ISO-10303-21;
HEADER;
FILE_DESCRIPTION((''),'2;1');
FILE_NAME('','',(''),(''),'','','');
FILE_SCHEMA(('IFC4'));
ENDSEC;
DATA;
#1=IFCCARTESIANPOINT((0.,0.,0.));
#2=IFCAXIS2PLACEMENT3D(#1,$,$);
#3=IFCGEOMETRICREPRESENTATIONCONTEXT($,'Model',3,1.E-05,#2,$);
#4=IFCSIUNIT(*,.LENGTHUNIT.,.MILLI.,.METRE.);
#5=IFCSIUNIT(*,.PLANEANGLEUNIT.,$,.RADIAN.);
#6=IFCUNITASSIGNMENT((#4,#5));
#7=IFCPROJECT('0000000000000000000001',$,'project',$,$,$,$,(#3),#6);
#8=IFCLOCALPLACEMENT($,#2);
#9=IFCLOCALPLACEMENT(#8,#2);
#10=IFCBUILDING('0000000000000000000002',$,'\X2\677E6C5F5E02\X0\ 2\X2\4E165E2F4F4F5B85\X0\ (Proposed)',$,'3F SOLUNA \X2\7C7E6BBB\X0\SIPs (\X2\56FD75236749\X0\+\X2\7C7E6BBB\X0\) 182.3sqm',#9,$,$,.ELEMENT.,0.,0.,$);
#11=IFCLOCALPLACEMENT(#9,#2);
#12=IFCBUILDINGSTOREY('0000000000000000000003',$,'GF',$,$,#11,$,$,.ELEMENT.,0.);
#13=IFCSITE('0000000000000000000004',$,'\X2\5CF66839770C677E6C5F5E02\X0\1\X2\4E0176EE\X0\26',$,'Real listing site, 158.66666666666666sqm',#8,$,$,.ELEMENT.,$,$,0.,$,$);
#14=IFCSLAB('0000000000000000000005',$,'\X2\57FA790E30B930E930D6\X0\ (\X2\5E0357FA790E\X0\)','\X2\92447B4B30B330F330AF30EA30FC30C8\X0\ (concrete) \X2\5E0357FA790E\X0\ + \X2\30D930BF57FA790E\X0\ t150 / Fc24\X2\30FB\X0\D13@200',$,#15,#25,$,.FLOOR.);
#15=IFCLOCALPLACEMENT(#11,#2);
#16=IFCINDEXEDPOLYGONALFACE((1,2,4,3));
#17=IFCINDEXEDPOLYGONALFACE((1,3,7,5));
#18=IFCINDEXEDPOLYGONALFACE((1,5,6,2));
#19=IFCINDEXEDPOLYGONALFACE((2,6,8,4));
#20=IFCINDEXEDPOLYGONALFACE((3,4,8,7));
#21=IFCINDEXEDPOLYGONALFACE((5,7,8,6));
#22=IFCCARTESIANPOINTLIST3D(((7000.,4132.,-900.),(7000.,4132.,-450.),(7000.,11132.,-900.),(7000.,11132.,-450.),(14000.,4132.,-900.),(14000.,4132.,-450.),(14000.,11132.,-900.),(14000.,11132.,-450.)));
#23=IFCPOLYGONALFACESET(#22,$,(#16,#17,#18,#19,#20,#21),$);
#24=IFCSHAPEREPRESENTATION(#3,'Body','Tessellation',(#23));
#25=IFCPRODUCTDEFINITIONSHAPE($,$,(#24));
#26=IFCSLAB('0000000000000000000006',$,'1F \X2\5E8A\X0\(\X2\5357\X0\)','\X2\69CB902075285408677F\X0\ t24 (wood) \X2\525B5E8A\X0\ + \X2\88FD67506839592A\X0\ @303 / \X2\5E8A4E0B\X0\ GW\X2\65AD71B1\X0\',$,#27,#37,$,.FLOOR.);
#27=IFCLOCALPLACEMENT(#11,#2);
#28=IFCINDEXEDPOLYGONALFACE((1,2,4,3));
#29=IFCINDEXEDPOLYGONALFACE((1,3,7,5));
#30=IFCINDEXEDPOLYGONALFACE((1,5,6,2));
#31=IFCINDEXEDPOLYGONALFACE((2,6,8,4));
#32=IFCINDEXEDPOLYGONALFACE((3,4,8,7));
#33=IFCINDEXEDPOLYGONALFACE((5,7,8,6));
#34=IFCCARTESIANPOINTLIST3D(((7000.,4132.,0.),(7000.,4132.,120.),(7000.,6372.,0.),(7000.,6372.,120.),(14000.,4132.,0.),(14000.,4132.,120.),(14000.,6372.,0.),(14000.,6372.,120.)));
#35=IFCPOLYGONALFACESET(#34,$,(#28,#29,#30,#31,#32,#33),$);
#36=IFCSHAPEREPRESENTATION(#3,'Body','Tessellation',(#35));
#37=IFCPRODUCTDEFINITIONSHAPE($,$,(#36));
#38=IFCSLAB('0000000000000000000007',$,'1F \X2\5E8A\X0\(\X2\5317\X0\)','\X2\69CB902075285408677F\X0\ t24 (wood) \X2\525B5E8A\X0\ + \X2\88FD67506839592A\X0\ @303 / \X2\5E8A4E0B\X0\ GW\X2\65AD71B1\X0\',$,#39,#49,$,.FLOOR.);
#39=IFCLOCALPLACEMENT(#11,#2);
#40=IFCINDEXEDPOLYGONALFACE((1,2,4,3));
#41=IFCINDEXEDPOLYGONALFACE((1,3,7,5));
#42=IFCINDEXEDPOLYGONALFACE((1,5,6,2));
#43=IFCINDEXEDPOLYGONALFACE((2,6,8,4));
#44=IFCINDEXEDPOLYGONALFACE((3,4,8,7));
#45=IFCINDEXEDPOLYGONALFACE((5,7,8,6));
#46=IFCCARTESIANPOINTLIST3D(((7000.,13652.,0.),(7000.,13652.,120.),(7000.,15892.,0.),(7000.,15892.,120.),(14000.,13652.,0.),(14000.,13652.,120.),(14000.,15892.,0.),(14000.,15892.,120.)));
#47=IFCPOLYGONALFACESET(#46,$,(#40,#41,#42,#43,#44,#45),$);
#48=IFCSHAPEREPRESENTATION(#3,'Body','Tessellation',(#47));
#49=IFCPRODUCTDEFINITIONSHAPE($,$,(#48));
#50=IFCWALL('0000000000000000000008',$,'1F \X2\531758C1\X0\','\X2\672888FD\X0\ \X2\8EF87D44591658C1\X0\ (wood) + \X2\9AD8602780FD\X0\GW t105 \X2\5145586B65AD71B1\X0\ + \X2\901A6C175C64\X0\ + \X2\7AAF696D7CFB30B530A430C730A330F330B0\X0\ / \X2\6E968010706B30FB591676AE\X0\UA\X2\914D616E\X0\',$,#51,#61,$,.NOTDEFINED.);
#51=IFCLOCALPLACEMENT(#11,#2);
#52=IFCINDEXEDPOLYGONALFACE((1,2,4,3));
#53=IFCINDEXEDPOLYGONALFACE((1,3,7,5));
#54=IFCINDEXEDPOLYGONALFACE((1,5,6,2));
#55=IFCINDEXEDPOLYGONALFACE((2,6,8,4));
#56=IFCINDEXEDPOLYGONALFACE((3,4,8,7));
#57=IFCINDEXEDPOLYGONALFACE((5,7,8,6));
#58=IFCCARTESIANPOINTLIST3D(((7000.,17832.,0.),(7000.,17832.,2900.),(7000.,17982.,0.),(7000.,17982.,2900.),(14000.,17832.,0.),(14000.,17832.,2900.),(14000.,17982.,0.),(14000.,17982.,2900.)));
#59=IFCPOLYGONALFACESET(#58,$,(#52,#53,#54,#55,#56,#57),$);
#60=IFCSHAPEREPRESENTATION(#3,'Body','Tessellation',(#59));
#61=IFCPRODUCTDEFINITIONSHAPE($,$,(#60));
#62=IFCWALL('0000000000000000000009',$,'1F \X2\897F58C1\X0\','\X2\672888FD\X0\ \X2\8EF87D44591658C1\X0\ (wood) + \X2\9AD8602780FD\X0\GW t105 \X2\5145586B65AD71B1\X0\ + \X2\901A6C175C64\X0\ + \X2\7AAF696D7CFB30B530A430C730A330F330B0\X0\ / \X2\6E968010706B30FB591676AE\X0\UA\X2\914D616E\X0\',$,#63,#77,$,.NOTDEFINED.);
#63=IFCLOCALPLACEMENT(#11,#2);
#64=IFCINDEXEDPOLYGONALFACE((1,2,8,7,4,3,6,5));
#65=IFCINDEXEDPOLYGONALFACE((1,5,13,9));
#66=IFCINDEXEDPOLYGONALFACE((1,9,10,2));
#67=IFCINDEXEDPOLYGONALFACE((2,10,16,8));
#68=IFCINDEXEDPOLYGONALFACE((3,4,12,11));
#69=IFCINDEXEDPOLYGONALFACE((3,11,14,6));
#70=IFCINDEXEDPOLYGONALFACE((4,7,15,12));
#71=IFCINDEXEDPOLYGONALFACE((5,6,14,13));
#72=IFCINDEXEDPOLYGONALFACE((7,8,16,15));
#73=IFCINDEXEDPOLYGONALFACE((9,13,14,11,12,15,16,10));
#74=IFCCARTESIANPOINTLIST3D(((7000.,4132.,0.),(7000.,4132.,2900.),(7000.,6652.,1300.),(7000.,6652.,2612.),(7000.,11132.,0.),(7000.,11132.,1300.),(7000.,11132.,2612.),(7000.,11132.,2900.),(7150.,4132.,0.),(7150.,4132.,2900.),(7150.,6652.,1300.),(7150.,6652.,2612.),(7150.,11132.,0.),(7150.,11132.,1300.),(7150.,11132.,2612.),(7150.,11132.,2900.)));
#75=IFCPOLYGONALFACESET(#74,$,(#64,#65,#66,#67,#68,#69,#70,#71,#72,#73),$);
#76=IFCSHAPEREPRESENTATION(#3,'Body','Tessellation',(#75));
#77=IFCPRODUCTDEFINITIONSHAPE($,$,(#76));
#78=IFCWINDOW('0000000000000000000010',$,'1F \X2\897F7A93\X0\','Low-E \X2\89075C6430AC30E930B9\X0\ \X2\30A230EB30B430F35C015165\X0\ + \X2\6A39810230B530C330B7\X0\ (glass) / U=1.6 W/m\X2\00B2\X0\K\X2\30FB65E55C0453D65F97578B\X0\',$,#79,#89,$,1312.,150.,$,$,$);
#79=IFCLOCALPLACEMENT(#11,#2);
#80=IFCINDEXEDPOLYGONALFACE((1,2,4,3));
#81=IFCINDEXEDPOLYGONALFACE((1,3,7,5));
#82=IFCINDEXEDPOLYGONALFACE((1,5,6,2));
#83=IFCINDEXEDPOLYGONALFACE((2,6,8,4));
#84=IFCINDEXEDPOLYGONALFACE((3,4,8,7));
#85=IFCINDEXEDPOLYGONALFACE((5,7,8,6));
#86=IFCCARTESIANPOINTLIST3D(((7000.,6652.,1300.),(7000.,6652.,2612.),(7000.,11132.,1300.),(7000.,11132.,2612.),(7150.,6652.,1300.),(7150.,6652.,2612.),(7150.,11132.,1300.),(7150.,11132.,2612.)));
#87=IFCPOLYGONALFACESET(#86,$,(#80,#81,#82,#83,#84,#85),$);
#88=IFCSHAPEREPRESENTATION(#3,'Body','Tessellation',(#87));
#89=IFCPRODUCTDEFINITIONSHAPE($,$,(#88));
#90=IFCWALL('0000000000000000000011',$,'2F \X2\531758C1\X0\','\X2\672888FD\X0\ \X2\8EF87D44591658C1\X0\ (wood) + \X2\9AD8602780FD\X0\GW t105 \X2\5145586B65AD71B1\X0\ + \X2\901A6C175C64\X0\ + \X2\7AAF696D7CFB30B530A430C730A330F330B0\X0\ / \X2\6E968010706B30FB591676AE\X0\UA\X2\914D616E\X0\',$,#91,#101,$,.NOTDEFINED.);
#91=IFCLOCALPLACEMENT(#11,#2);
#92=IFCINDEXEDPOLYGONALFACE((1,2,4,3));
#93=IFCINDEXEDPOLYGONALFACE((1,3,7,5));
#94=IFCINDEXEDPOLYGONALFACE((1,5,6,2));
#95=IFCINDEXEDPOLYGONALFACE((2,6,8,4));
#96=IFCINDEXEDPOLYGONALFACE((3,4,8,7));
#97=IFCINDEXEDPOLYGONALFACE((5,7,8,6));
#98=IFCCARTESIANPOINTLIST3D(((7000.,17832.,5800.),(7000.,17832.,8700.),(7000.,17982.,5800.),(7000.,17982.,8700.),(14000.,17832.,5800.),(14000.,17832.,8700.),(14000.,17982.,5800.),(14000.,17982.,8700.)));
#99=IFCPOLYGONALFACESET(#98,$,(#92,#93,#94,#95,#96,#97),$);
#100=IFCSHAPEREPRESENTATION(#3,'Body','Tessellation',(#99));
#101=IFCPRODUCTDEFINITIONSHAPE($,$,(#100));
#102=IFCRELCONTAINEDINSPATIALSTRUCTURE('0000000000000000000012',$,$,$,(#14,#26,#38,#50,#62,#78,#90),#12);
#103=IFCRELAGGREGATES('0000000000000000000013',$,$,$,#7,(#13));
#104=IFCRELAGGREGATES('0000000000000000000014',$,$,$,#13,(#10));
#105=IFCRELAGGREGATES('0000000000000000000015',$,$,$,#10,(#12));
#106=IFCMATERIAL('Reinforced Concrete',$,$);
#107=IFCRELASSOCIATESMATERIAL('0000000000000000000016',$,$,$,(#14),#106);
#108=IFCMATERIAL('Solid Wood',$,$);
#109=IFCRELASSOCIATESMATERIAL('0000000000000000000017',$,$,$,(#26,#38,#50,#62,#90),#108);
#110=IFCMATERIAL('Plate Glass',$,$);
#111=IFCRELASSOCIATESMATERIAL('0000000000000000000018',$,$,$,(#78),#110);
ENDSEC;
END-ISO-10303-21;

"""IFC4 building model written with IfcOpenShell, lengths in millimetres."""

from ifc_helpers import new_model, si_unit, frame, frame_2d, origin, place, context, project, spatial, rectangle, extrude, material, element, fill, save


model = new_model("IFC4")

# Units and contexts
model_context = context("Model", 3, precision=1e-05, world=origin())
ifc_project = project(units=[si_unit("LENGTHUNIT", "METRE", prefix="MILLI"), si_unit("PLANEANGLEUNIT", "RADIAN")], contexts=[model_context])

# Site, building, storey
site_placement = place(None, origin())
site = spatial("IfcSite", under=ifc_project, at=site_placement, Name="島根県松江市1丁目26", ObjectType="Real listing site, 158.66666666666666sqm", CompositionType="ELEMENT", RefElevation=0.0)
building_placement = place(site_placement, origin())
building = spatial("IfcBuilding", under=site, at=building_placement, Name="松江市 2世帯住宅 (Proposed)", ObjectType="3F SOLUNA 籾殻SIPs (国産杉+籾殻) 182.3sqm", CompositionType="ELEMENT", ElevationOfRefHeight=0.0, ElevationOfTerrain=0.0)
storey_placement = place(building_placement, origin())
storey = spatial("IfcBuildingStorey", under=building, at=storey_placement, Name="GF", CompositionType="ELEMENT", Elevation=0.0)

# Slabs
ifc_material_1 = material(Name="Reinforced Concrete")
slab_1_placement = place(storey_placement, frame((3500.0, 2066.0, -450.0)))
element("IfcSlab", 1, at=slab_1_placement, inside=storey, material=ifc_material_1, Name="基礎スラブ (布基礎)", Description="鉄筋コンクリート (concrete) 布基礎 + ベタ基礎 t150 / Fc24・D13@200", PredefinedType="FLOOR", context=model_context, shape_type="SweptSolid", body=[
    extrude(rectangle(XDim=7000.0, YDim=7000.0, at=frame_2d((3500.0, 3500.0))), frame((3500.0, 2066.0, -450.0)), (0.0, 0.0, 1.0), 450.0),
])
ifc_material_2 = material(Name="Solid Wood")
slab_2_placement = place(storey_placement, frame((3500.0, 2066.0, 0.0)))
element("IfcSlab", 2, at=slab_2_placement, inside=storey, material=ifc_material_2, Name="1F 床(南)", Description="構造用合板 t24 (wood) 剛床 + 製材根太 @303 / 床下 GW断熱", PredefinedType="FLOOR", context=model_context, shape_type="SweptSolid", body=[
    extrude(rectangle(XDim=7000.0, YDim=2240.0, at=frame_2d((3500.0, 1120.0))), frame((3500.0, 2066.0, 0.0)), (0.0, 0.0, 1.0), 120.0),
])
slab_3_placement = place(storey_placement, frame((3500.0, 6826.0, 0.0)))
element("IfcSlab", 3, at=slab_3_placement, inside=storey, material=ifc_material_2, Name="1F 床(北)", Description="構造用合板 t24 (wood) 剛床 + 製材根太 @303 / 床下 GW断熱", PredefinedType="FLOOR", context=model_context, shape_type="SweptSolid", body=[
    extrude(rectangle(XDim=7000.0, YDim=2240.0, at=frame_2d((3500.0, 1120.0))), frame((3500.0, 6826.0, 0.0)), (0.0, 0.0, 1.0), 120.0),
])

# Shared definitions
ifc_material_3 = material(Name="Plate Glass")

# Wall
wall_1_placement = place(storey_placement, frame((3500.0, 8916.0, 0.0)))
element("IfcWall", 4, at=wall_1_placement, inside=storey, material=ifc_material_2, Name="1F 北壁", Description="木製 軸組外壁 (wood) + 高性能GW t105 充填断熱 + 通気層 + 窯業系サイディング / 準耐火・外皮UA配慮", PredefinedType="NOTDEFINED", context=model_context, shape_type="SweptSolid", body=[
    extrude(rectangle(XDim=7000.0, YDim=150.0, at=frame_2d((3500.0, 75.0))), frame((3500.0, 8916.0, 0.0)), (0.0, 0.0, 1.0), 2900.0),
])

# Wall, opening, window
wall_2_placement = place(storey_placement, frame((3500.0, 2066.0, 0.0)))
wall_2 = element("IfcWall", 5, at=wall_2_placement, inside=storey, material=ifc_material_2, Name="1F 西壁", Description="木製 軸組外壁 (wood) + 高性能GW t105 充填断熱 + 通気層 + 窯業系サイディング / 準耐火・外皮UA配慮", PredefinedType="NOTDEFINED", context=model_context, shape_type="SweptSolid", body=[
    extrude(rectangle(XDim=150.0, YDim=7000.0, at=frame_2d((75.0, 3500.0))), frame((3500.0, 2066.0, 0.0)), (0.0, 0.0, 1.0), 2900.0),
])
opening_1_placement = place(storey_placement, frame((3500.0, 3326.0, 650.0)))
opening_1 = element("IfcOpeningElement", 6, at=opening_1_placement, cuts=wall_2, PredefinedType="NOTDEFINED", context=model_context, shape_type="SweptSolid", body=[
    extrude(rectangle(XDim=150.0, YDim=4480.0, at=frame_2d((75.0, 2240.0))), frame((3500.0, 3326.0, 650.0)), (0.0, 0.0, 1.0), 1312.0),
])
window_1_placement = place(storey_placement, frame((3500.0, 3326.0, 650.0)))
window_1 = element("IfcWindow", 7, at=window_1_placement, inside=storey, material=ifc_material_3, Name="1F 西窓", Description="Low-E 複層ガラス アルゴン封入 + 樹脂サッシ (glass) / U=1.6 W/m²K・日射取得型", OverallHeight=1312.0, OverallWidth=150.0, context=model_context, shape_type="SweptSolid", body=[
    extrude(rectangle(XDim=150.0, YDim=4480.0, at=frame_2d((75.0, 2240.0))), frame((3500.0, 3326.0, 650.0)), (0.0, 0.0, 1.0), 1312.0),
])
fill(opening_1, window_1)

# Wall
wall_3_placement = place(storey_placement, frame((3500.0, 8916.0, 2900.0)))
element("IfcWall", 8, at=wall_3_placement, inside=storey, material=ifc_material_2, Name="2F 北壁", Description="木製 軸組外壁 (wood) + 高性能GW t105 充填断熱 + 通気層 + 窯業系サイディング / 準耐火・外皮UA配慮", PredefinedType="NOTDEFINED", context=model_context, shape_type="SweptSolid", body=[
    extrude(rectangle(XDim=7000.0, YDim=150.0, at=frame_2d((3500.0, 75.0))), frame((3500.0, 8916.0, 2900.0)), (0.0, 0.0, 1.0), 2900.0),
])

save(model, "model.ifc")
